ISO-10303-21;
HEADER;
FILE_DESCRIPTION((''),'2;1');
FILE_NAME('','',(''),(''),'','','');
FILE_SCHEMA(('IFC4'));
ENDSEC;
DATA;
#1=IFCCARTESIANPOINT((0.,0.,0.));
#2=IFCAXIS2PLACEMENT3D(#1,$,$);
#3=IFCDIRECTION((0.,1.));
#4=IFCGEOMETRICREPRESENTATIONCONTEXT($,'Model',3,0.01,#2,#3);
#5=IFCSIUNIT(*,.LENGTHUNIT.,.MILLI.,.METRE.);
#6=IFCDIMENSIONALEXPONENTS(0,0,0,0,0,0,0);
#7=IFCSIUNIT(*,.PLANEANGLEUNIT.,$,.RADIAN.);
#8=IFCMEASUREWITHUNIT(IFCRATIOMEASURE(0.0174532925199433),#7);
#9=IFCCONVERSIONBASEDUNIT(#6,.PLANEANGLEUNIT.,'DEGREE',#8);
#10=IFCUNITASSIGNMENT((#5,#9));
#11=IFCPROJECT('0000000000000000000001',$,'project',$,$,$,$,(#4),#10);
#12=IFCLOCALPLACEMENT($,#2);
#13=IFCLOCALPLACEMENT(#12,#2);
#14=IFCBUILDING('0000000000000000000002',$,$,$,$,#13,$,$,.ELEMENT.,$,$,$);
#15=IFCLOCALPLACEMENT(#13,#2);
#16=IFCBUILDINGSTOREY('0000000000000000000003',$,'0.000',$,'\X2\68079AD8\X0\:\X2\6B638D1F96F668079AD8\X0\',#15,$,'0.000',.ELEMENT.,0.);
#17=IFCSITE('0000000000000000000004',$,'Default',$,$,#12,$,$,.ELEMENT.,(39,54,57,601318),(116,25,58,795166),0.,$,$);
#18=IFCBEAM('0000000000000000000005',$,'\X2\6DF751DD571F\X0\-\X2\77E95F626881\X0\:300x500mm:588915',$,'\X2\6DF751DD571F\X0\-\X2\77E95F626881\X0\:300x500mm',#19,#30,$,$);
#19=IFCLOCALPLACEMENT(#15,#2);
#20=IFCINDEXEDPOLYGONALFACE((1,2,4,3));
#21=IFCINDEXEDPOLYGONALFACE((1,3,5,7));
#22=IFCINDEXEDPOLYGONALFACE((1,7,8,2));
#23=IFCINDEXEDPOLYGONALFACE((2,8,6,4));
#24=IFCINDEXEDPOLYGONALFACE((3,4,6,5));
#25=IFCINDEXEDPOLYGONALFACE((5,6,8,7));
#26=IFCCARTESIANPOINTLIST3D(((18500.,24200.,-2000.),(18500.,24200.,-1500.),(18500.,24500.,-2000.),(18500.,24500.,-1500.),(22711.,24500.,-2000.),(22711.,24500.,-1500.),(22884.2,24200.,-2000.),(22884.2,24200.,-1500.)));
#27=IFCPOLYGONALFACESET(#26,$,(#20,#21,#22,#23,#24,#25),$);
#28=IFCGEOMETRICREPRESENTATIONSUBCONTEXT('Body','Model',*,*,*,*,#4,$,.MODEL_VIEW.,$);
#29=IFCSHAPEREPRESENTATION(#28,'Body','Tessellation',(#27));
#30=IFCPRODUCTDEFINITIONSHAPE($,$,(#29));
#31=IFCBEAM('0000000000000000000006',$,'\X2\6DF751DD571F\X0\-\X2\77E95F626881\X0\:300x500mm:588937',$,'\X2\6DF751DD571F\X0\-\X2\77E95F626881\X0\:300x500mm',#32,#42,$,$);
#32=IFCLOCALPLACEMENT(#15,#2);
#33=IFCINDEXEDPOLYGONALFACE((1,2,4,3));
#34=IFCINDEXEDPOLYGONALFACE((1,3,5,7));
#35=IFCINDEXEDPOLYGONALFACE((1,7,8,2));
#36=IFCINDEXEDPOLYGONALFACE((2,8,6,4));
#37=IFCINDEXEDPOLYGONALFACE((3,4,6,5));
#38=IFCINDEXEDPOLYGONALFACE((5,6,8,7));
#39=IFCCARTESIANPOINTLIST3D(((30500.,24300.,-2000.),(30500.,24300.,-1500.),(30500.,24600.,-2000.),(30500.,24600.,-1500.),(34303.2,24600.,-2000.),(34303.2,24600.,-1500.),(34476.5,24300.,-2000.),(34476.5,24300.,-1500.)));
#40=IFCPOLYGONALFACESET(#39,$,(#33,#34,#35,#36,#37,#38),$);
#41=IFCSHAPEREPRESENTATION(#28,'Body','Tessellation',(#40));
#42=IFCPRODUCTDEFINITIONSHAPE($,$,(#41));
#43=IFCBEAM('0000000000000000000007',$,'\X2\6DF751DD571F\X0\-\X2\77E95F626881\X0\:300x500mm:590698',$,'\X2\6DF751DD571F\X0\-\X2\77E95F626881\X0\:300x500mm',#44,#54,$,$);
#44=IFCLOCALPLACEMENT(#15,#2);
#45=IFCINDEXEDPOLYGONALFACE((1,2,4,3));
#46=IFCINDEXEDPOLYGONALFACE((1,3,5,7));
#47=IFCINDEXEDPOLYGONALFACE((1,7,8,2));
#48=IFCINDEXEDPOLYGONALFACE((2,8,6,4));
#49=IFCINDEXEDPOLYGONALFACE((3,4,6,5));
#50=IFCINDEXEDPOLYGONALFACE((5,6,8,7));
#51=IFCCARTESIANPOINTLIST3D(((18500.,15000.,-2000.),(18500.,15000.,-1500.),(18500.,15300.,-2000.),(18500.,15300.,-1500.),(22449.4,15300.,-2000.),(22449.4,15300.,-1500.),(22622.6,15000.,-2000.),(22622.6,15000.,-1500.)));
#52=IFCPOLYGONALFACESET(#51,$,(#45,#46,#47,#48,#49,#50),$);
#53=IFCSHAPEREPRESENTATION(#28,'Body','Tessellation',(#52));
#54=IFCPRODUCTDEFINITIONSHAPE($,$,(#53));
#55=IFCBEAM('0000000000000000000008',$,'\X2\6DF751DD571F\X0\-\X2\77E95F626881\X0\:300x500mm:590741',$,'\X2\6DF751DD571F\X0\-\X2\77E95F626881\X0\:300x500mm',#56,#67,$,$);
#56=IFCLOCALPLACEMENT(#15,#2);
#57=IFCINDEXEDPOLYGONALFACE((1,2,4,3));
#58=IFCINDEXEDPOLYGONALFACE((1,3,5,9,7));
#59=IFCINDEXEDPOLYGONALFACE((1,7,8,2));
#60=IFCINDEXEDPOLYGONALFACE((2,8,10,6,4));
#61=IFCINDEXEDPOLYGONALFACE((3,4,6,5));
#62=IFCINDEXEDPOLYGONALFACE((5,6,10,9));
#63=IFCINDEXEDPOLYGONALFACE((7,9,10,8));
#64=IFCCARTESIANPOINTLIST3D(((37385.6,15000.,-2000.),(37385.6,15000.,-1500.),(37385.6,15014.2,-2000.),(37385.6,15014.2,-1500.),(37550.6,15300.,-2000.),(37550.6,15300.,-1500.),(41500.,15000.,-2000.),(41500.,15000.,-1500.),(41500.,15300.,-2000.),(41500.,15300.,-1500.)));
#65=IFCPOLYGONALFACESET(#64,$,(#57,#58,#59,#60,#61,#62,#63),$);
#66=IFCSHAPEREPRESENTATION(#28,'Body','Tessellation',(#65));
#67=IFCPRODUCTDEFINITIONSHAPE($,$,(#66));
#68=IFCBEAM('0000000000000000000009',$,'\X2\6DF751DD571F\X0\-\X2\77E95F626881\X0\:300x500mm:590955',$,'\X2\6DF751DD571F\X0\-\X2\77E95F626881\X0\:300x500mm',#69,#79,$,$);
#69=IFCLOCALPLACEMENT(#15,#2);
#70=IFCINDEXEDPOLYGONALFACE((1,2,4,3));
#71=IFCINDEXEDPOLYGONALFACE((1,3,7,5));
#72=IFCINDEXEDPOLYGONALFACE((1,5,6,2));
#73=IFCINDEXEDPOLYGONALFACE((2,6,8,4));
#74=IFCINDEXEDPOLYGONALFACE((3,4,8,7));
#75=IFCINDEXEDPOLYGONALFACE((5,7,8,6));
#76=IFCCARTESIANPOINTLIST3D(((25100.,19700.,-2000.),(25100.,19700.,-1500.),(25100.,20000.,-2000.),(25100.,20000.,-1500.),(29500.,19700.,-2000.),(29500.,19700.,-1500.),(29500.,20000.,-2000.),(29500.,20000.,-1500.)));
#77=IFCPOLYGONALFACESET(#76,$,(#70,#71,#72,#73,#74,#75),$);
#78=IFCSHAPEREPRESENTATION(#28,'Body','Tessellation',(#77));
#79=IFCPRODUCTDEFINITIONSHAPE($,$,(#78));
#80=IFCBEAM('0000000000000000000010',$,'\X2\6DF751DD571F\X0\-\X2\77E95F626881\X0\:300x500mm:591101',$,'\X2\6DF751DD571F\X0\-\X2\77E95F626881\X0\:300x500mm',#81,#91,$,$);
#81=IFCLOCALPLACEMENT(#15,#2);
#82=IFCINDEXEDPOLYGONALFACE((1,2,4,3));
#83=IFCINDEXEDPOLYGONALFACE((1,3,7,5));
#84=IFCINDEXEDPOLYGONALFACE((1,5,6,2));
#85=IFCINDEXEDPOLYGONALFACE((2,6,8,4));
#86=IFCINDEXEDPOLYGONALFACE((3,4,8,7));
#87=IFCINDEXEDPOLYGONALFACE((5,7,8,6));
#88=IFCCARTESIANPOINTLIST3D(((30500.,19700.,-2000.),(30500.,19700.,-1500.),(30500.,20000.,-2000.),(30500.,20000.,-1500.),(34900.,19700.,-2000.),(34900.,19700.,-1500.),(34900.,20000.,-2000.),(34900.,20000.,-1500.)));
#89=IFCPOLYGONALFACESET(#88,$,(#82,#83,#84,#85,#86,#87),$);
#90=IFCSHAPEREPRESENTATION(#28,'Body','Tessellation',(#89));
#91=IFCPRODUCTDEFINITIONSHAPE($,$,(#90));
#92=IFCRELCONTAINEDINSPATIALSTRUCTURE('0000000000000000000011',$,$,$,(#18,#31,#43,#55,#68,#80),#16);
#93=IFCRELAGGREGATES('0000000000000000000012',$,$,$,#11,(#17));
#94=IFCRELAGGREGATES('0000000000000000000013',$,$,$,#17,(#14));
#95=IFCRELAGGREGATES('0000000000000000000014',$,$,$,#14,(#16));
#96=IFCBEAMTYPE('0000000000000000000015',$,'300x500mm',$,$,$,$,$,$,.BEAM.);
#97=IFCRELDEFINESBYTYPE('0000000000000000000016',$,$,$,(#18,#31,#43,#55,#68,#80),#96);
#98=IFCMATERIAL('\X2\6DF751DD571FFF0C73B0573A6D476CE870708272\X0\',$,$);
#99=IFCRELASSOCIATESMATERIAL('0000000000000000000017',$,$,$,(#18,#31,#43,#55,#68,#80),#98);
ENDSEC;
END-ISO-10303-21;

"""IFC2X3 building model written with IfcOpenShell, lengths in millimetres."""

from ifc_helpers import new_model, entity, si_unit, converted_unit, direction, frame, frame_2d, origin, place, context, subcontext, project, spatial, rectangle, extrude, clip, halfspace, material, type_object, element, save


model = new_model("IFC2X3")

# Units and contexts
model_context = context("Model", 3, precision=0.01, world=origin(), true_north=direction((0.0, 1.0)))
body_context = subcontext(model_context, "Body", "Model", "MODEL_VIEW")
ifc_project = project(units=[si_unit("LENGTHUNIT", "METRE", prefix="MILLI"), converted_unit("PLANEANGLEUNIT", "DEGREE", entity("IfcRatioMeasure", 0.0174532925199433), si_unit("PLANEANGLEUNIT", "RADIAN"), dimensions=[0, 0, 0, 0, 0, 0, 0])], contexts=[model_context])

# Site, building, storey
site_placement = place(None, origin())
site = spatial("IfcSite", under=ifc_project, at=site_placement, Name="Default", CompositionType="ELEMENT", RefLatitude=(39, 54, 57, 601318), RefLongitude=(116, 25, 58, 795166), RefElevation=0.0)
building_placement = place(site_placement, origin())
building = spatial("IfcBuilding", under=site, at=building_placement, CompositionType="ELEMENT")
storey_placement = place(building_placement, origin())
storey = spatial("IfcBuildingStorey", under=building, at=storey_placement, Name="0.000", ObjectType="标高:正负零标高", LongName="0.000", CompositionType="ELEMENT", Elevation=0.0)

# Shared definitions
ifc_material = material(Name="混凝土，现场浇注灰色")

# Beams
beam_type_1 = type_object("IfcBeamType", Name="300x500mm", PredefinedType="BEAM")
beam_1_placement = place(storey_placement, frame((18500.0, 24350.0, -1500.0)))
element("IfcBeam", 1, at=beam_1_placement, inside=storey, type_object=beam_type_1, material=ifc_material, Name="混凝土-矩形梁:300x500mm:588915", ObjectType="混凝土-矩形梁:300x500mm", context=body_context, shape_type="Clipping", body=[
    clip(extrude(rectangle(XDim=500.0, YDim=300.0, at=frame_2d((0.0, 0.0), x_axis=(1.0, 0.0))), frame((0.0, 0.0, -250.0), z_axis=(1.0, 0.0, 0.0), x_axis=(0.0, 0.0, -1.0)), (0.0, 0.0, 1.0), 4384.2), halfspace(frame((5386.3, -1885.3, 0.0), z_axis=(0.865977, 0.500083, 0.0), x_axis=(0.0, 0.0, -1.0)), False)),
])
beam_2_placement = place(storey_placement, frame((30500.0, 24450.0, -1500.0)))
element("IfcBeam", 2, at=beam_2_placement, inside=storey, type_object=beam_type_1, material=ifc_material, Name="混凝土-矩形梁:300x500mm:588937", ObjectType="混凝土-矩形梁:300x500mm", context=body_context, shape_type="Clipping", body=[
    clip(extrude(rectangle(XDim=500.0, YDim=300.0, at=frame_2d((0.0, 0.0), x_axis=(1.0, 0.0))), frame((0.0, 0.0, -250.0), z_axis=(1.0, 0.0, 0.0), x_axis=(0.0, 0.0, -1.0)), (0.0, 0.0, 1.0), 3976.5), halfspace(frame((5036.3, -1985.3, 0.0), z_axis=(0.865977, 0.500083, 0.0), x_axis=(0.0, 0.0, -1.0)), False)),
])
beam_3_placement = place(storey_placement, frame((18500.0, 15150.0, -1500.0)))
element("IfcBeam", 3, at=beam_3_placement, inside=storey, type_object=beam_type_1, material=ifc_material, Name="混凝土-矩形梁:300x500mm:590698", ObjectType="混凝土-矩形梁:300x500mm", context=body_context, shape_type="Clipping", body=[
    clip(extrude(rectangle(XDim=500.0, YDim=300.0, at=frame_2d((0.0, 0.0), x_axis=(1.0, 0.0))), frame((0.0, 0.0, -250.0), z_axis=(1.0, 0.0, 0.0), x_axis=(0.0, 0.0, -1.0)), (0.0, 0.0, 1.0), 4122.6), halfspace(frame((5211.4, -2035.3, 0.0), z_axis=(0.865977, 0.500083, 0.0), x_axis=(0.0, 0.0, -1.0)), False)),
])
beam_4_placement = place(storey_placement, frame((37385.6, 15150.0, -1500.0)))
element("IfcBeam", 4, at=beam_4_placement, inside=storey, type_object=beam_type_1, material=ifc_material, Name="混凝土-矩形梁:300x500mm:590741", ObjectType="混凝土-矩形梁:300x500mm", context=body_context, shape_type="Clipping", body=[
    clip(extrude(rectangle(XDim=500.0, YDim=300.0, at=frame_2d((0.0, 0.0), x_axis=(1.0, 0.0))), frame((0.0, 0.0, -250.0), z_axis=(1.0, 0.0, 0.0), x_axis=(0.0, 0.0, -1.0)), (0.0, 0.0, 1.0), 4114.4), halfspace(frame((391.8, 542.6, 0.0), z_axis=(-0.865977, 0.500083, 0.0), x_axis=(0.0, 0.0, -1.0)), False)),
])
beam_5_placement = place(storey_placement, frame((25100.0, 19850.0, -1500.0)))
element("IfcBeam", 5, at=beam_5_placement, inside=storey, type_object=beam_type_1, material=ifc_material, Name="混凝土-矩形梁:300x500mm:590955", ObjectType="混凝土-矩形梁:300x500mm", context=body_context, shape_type="SweptSolid", body=[
    extrude(rectangle(XDim=500.0, YDim=300.0, at=frame_2d((0.0, 0.0), x_axis=(1.0, 0.0))), frame((0.0, 0.0, -250.0), z_axis=(1.0, 0.0, 0.0), x_axis=(0.0, 0.0, -1.0)), (0.0, 0.0, 1.0), 4400.0),
])
beam_6_placement = place(storey_placement, frame((30500.0, 19850.0, -1500.0)))
element("IfcBeam", 6, at=beam_6_placement, inside=storey, type_object=beam_type_1, material=ifc_material, Name="混凝土-矩形梁:300x500mm:591101", ObjectType="混凝土-矩形梁:300x500mm", context=body_context, shape_type="SweptSolid", body=[
    extrude(rectangle(XDim=500.0, YDim=300.0, at=frame_2d((0.0, 0.0), x_axis=(1.0, 0.0))), frame((0.0, 0.0, -250.0), z_axis=(1.0, 0.0, 0.0), x_axis=(0.0, 0.0, -1.0)), (0.0, 0.0, 1.0), 4400.0),
])

save(model, "model.ifc")
